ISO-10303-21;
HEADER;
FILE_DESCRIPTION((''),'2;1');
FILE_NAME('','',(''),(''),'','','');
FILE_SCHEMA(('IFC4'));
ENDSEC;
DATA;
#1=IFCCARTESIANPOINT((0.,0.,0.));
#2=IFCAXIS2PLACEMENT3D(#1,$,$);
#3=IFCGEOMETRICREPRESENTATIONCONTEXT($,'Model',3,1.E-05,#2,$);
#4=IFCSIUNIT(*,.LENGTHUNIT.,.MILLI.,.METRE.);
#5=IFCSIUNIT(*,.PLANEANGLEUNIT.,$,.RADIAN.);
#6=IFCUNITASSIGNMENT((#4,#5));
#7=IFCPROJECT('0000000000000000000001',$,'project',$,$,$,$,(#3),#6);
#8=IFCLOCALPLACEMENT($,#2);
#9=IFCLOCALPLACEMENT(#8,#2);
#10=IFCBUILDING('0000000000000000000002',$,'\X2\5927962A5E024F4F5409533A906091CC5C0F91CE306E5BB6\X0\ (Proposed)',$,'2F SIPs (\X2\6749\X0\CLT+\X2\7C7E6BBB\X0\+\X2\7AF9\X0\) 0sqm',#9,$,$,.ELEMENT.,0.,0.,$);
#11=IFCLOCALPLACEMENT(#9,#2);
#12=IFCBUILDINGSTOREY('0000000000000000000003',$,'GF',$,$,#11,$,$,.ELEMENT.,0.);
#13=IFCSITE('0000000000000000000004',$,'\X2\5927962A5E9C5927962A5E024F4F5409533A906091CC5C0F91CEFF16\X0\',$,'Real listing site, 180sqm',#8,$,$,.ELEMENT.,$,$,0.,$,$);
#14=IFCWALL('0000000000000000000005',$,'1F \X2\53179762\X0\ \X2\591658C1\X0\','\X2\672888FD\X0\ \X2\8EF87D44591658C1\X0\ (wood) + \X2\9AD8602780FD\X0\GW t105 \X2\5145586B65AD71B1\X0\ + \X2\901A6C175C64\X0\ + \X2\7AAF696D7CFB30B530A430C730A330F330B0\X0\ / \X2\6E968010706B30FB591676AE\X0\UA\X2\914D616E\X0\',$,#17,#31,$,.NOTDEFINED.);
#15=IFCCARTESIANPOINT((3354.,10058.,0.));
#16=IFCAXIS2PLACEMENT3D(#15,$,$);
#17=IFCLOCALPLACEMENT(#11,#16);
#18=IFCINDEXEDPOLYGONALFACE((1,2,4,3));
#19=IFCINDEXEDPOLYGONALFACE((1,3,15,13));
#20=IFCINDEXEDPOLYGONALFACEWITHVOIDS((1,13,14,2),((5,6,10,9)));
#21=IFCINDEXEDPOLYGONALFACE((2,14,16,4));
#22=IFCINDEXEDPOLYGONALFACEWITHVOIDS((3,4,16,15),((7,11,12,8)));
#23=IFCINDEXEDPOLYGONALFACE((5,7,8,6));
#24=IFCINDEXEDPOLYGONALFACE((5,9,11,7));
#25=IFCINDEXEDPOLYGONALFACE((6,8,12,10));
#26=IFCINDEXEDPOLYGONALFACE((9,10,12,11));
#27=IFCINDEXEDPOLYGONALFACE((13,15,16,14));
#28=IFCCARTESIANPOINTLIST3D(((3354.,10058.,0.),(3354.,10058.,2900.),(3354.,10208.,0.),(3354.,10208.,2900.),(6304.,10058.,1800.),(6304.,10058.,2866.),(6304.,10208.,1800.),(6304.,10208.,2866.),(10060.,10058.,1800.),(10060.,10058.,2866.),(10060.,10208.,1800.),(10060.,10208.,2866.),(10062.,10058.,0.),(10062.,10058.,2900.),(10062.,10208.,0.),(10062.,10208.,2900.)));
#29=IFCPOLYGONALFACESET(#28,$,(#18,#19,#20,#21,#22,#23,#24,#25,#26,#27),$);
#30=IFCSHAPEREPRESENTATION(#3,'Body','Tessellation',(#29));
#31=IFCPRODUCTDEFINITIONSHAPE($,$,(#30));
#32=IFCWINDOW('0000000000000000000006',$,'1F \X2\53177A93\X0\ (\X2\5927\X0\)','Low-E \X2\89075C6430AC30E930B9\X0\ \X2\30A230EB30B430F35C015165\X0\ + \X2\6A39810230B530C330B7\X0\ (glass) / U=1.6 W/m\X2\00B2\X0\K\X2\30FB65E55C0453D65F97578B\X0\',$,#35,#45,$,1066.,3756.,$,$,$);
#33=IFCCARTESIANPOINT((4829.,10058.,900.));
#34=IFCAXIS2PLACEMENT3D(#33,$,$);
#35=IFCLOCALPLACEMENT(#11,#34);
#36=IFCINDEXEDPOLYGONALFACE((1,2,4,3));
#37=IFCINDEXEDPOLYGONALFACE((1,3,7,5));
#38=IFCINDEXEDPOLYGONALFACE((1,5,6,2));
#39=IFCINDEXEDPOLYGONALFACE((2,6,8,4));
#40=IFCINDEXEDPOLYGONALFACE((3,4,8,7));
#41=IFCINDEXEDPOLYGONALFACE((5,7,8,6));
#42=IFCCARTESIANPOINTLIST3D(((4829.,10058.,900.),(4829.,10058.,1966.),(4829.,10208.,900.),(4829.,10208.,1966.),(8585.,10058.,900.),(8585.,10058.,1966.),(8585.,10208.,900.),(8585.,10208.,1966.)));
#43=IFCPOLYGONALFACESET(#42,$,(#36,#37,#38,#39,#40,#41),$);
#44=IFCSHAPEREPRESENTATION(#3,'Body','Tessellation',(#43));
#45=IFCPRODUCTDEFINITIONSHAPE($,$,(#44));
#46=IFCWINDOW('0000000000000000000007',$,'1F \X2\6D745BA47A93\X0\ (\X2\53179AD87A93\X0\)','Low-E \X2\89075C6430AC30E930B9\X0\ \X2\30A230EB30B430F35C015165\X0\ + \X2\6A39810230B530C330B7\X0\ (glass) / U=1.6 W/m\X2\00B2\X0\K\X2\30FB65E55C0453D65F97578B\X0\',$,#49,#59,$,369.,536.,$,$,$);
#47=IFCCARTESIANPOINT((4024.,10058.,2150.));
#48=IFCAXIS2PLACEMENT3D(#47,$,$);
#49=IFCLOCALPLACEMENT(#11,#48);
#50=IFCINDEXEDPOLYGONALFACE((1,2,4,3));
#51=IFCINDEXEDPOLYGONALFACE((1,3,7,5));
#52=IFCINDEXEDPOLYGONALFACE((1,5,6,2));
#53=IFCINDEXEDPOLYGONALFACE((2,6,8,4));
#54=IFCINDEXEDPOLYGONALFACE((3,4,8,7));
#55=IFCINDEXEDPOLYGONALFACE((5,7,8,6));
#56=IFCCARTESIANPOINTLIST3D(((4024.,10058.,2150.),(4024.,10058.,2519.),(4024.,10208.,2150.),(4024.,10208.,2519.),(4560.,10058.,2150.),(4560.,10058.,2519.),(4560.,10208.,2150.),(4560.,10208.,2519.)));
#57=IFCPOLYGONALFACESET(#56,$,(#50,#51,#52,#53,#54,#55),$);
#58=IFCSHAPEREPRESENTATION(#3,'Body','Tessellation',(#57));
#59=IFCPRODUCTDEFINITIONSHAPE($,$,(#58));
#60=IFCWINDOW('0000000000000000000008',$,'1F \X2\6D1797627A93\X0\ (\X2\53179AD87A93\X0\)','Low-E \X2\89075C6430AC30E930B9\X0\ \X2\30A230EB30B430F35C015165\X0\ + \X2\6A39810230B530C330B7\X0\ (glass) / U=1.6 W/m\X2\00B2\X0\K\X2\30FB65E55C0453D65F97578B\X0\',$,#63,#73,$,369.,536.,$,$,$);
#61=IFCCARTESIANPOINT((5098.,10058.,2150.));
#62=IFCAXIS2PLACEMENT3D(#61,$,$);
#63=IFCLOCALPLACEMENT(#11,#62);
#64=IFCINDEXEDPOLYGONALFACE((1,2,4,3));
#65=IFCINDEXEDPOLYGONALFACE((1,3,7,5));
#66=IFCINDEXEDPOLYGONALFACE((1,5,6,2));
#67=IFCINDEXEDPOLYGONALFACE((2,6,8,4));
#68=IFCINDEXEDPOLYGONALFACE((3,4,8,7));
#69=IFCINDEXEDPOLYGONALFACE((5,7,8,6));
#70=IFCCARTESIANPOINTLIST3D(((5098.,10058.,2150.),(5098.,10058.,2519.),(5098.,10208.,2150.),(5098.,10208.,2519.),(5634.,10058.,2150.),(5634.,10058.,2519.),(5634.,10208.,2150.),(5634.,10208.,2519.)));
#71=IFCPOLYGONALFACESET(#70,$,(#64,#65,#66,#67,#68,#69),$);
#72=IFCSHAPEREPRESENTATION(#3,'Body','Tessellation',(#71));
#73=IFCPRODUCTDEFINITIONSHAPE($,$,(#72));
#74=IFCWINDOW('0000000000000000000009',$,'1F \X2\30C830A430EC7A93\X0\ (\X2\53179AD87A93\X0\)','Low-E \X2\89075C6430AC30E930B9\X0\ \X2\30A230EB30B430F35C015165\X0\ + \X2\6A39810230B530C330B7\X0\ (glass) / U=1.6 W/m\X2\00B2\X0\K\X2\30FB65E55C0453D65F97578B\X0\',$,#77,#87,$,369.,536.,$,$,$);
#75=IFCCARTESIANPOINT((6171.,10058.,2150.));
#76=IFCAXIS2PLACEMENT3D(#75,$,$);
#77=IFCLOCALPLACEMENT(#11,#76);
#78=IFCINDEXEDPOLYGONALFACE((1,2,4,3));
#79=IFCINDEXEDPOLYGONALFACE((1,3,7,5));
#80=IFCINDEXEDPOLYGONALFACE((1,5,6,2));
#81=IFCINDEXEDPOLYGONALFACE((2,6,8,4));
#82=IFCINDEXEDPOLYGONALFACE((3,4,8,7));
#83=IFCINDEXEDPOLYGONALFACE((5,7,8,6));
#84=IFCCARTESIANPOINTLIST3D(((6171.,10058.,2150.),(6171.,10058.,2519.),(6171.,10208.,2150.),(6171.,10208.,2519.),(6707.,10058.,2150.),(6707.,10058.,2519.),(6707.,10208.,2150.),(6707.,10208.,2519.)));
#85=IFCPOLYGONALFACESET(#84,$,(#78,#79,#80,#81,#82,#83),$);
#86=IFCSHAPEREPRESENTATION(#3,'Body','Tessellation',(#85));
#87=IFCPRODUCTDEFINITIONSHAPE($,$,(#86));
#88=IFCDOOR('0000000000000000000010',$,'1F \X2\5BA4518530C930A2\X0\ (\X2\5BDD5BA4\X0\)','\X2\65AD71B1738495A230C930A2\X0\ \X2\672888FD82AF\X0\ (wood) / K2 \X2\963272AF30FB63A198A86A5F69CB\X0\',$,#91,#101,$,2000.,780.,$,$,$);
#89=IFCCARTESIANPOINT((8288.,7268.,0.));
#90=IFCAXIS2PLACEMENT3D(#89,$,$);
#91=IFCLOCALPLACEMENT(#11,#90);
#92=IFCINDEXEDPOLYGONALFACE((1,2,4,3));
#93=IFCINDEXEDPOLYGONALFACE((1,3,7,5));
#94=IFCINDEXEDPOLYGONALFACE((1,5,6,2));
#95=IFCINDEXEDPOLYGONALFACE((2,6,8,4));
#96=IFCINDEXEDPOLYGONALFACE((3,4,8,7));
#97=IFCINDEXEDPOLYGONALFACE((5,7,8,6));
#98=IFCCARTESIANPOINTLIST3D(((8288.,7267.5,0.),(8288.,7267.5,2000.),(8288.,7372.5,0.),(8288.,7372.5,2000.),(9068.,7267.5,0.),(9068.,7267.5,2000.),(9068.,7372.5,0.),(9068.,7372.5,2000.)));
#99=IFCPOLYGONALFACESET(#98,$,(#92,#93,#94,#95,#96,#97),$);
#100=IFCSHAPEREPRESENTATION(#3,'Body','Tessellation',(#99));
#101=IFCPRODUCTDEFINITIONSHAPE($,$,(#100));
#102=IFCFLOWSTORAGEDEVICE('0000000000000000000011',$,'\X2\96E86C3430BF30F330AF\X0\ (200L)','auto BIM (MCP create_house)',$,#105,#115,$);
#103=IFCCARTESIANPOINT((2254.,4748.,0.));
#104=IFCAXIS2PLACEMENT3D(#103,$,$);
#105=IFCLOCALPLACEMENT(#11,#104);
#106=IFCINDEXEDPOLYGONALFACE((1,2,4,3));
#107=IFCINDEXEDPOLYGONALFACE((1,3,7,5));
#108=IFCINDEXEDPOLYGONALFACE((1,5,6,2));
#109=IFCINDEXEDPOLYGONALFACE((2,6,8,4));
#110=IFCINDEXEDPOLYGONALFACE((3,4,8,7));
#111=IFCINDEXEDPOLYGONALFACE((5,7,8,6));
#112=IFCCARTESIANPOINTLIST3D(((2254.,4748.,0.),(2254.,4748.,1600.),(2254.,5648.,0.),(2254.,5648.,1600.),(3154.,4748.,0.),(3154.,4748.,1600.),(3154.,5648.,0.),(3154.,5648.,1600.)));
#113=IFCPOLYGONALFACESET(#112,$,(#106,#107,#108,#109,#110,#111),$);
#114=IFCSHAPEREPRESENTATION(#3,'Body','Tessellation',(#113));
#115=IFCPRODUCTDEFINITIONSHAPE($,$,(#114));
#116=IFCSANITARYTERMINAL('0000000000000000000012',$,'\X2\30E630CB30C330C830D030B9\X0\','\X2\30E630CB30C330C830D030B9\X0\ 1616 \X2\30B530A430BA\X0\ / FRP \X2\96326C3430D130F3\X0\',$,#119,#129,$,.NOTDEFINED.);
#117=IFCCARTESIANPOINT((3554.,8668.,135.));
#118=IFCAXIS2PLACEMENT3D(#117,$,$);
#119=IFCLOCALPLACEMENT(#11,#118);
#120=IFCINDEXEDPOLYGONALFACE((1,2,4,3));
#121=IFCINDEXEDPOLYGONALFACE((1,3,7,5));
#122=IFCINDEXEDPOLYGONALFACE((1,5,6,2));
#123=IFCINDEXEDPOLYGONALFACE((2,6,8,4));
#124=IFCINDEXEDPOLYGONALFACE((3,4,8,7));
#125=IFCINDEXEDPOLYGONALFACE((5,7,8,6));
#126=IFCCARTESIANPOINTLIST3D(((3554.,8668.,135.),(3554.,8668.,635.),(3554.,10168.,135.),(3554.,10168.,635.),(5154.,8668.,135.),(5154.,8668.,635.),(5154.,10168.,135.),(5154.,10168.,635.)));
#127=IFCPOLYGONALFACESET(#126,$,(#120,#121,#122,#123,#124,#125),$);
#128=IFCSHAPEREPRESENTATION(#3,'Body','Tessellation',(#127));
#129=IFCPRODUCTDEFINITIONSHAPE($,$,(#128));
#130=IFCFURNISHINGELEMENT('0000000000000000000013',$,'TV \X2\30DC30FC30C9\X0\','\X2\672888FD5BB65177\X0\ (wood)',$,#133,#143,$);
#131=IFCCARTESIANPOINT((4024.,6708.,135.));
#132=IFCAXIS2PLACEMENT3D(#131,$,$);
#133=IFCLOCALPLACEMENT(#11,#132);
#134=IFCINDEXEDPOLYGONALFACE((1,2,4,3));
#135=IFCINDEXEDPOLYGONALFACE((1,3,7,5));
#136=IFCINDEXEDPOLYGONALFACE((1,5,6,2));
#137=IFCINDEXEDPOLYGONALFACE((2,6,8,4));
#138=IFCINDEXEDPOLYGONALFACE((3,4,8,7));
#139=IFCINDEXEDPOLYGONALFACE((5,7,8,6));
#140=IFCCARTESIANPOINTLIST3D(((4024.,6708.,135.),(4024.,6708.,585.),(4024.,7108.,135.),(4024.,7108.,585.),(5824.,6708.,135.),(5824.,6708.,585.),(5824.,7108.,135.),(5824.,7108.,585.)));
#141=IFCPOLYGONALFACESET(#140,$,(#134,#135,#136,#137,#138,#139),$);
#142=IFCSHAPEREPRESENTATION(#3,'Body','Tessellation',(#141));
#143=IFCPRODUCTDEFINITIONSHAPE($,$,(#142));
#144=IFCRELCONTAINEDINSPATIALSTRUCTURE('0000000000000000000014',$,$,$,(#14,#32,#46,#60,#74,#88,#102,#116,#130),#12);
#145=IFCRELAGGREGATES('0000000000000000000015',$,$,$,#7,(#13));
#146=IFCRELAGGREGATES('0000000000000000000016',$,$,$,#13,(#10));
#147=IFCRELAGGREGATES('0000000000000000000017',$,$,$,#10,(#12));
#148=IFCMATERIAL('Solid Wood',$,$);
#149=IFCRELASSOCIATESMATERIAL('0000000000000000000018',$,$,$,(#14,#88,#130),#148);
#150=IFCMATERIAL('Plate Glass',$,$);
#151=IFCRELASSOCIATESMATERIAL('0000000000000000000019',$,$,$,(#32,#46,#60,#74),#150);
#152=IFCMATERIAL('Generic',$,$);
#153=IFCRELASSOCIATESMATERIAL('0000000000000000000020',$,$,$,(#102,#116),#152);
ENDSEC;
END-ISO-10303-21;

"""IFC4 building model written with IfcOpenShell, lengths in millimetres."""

from ifc_helpers import new_model, si_unit, frame, frame_2d, origin, place, context, project, spatial, rectangle, extrude, material, element, fill, save


model = new_model("IFC4")

# Units and contexts
model_context = context("Model", 3, precision=1e-05, world=origin())
ifc_project = project(units=[si_unit("LENGTHUNIT", "METRE", prefix="MILLI"), si_unit("PLANEANGLEUNIT", "RADIAN")], contexts=[model_context])

# Site, building, storey
site_placement = place(None, origin())
site = spatial("IfcSite", under=ifc_project, at=site_placement, Name="大阪府大阪市住吉区遠里小野６", ObjectType="Real listing site, 180sqm", CompositionType="ELEMENT", RefElevation=0.0)
building_placement = place(site_placement, origin())
building = spatial("IfcBuilding", under=site, at=building_placement, Name="大阪市住吉区遠里小野の家 (Proposed)", ObjectType="2F SIPs (杉CLT+籾殻+竹) 0sqm", CompositionType="ELEMENT", ElevationOfRefHeight=0.0, ElevationOfTerrain=0.0)
storey_placement = place(building_placement, origin())
storey = spatial("IfcBuildingStorey", under=building, at=storey_placement, Name="GF", CompositionType="ELEMENT", Elevation=0.0)

# Wall, openings, windows
ifc_material_1 = material(Name="Solid Wood")
wall_1_placement = place(storey_placement, frame((3354.0, 10058.0, 0.0)))
wall_1 = element("IfcWall", 1, at=wall_1_placement, inside=storey, material=ifc_material_1, Name="1F 北面 外壁", Description="木製 軸組外壁 (wood) + 高性能GW t105 充填断熱 + 通気層 + 窯業系サイディング / 準耐火・外皮UA配慮", PredefinedType="NOTDEFINED", context=model_context, shape_type="SweptSolid", body=[
    extrude(rectangle(XDim=6708.0, YDim=150.0, at=frame_2d((3354.0, 75.0))), frame((3354.0, 10058.0, 0.0)), (0.0, 0.0, 1.0), 2900.0),
])
opening_1_placement = place(storey_placement, frame((4829.0, 10058.0, 900.0)))
opening_1 = element("IfcOpeningElement", 2, at=opening_1_placement, cuts=wall_1, PredefinedType="NOTDEFINED", context=model_context, shape_type="SweptSolid", body=[
    extrude(rectangle(XDim=3756.0, YDim=150.0, at=frame_2d((1878.0, 75.0))), frame((4829.0, 10058.0, 900.0)), (0.0, 0.0, 1.0), 1066.0),
])
opening_2_placement = place(storey_placement, frame((4024.0, 10058.0, 2150.0)))
opening_2 = element("IfcOpeningElement", 3, at=opening_2_placement, cuts=wall_1, PredefinedType="NOTDEFINED", context=model_context, shape_type="SweptSolid", body=[
    extrude(rectangle(XDim=536.0, YDim=150.0, at=frame_2d((268.0, 75.0))), frame((4024.0, 10058.0, 2150.0)), (0.0, 0.0, 1.0), 369.0),
])
opening_3_placement = place(storey_placement, frame((5098.0, 10058.0, 2150.0)))
opening_3 = element("IfcOpeningElement", 4, at=opening_3_placement, cuts=wall_1, PredefinedType="NOTDEFINED", context=model_context, shape_type="SweptSolid", body=[
    extrude(rectangle(XDim=536.0, YDim=150.0, at=frame_2d((268.0, 75.0))), frame((5098.0, 10058.0, 2150.0)), (0.0, 0.0, 1.0), 369.0),
])
opening_4_placement = place(storey_placement, frame((6171.0, 10058.0, 2150.0)))
opening_4 = element("IfcOpeningElement", 5, at=opening_4_placement, cuts=wall_1, PredefinedType="NOTDEFINED", context=model_context, shape_type="SweptSolid", body=[
    extrude(rectangle(XDim=536.0, YDim=150.0, at=frame_2d((268.0, 75.0))), frame((6171.0, 10058.0, 2150.0)), (0.0, 0.0, 1.0), 369.0),
])
ifc_material_2 = material(Name="Plate Glass")
window_1_placement = place(storey_placement, frame((4829.0, 10058.0, 900.0)))
window_1 = element("IfcWindow", 6, at=window_1_placement, inside=storey, material=ifc_material_2, Name="1F 北窓 (大)", Description="Low-E 複層ガラス アルゴン封入 + 樹脂サッシ (glass) / U=1.6 W/m²K・日射取得型", OverallHeight=1066.0, OverallWidth=3756.0, context=model_context, shape_type="SweptSolid", body=[
    extrude(rectangle(XDim=3756.0, YDim=150.0, at=frame_2d((1878.0, 75.0))), frame((4829.0, 10058.0, 900.0)), (0.0, 0.0, 1.0), 1066.0),
])
fill(opening_1, window_1)
window_2_placement = place(storey_placement, frame((4024.0, 10058.0, 2150.0)))
window_2 = element("IfcWindow", 7, at=window_2_placement, inside=storey, material=ifc_material_2, Name="1F 浴室窓 (北高窓)", Description="Low-E 複層ガラス アルゴン封入 + 樹脂サッシ (glass) / U=1.6 W/m²K・日射取得型", OverallHeight=369.0, OverallWidth=536.0, context=model_context, shape_type="SweptSolid", body=[
    extrude(rectangle(XDim=536.0, YDim=150.0, at=frame_2d((268.0, 75.0))), frame((4024.0, 10058.0, 2150.0)), (0.0, 0.0, 1.0), 369.0),
])
fill(opening_2, window_2)
window_3_placement = place(storey_placement, frame((5098.0, 10058.0, 2150.0)))
window_3 = element("IfcWindow", 8, at=window_3_placement, inside=storey, material=ifc_material_2, Name="1F 洗面窓 (北高窓)", Description="Low-E 複層ガラス アルゴン封入 + 樹脂サッシ (glass) / U=1.6 W/m²K・日射取得型", OverallHeight=369.0, OverallWidth=536.0, context=model_context, shape_type="SweptSolid", body=[
    extrude(rectangle(XDim=536.0, YDim=150.0, at=frame_2d((268.0, 75.0))), frame((5098.0, 10058.0, 2150.0)), (0.0, 0.0, 1.0), 369.0),
])
fill(opening_3, window_3)
window_4_placement = place(storey_placement, frame((6171.0, 10058.0, 2150.0)))
window_4 = element("IfcWindow", 9, at=window_4_placement, inside=storey, material=ifc_material_2, Name="1F トイレ窓 (北高窓)", Description="Low-E 複層ガラス アルゴン封入 + 樹脂サッシ (glass) / U=1.6 W/m²K・日射取得型", OverallHeight=369.0, OverallWidth=536.0, context=model_context, shape_type="SweptSolid", body=[
    extrude(rectangle(XDim=536.0, YDim=150.0, at=frame_2d((268.0, 75.0))), frame((6171.0, 10058.0, 2150.0)), (0.0, 0.0, 1.0), 369.0),
])
fill(opening_4, window_4)

# Door
door_1_placement = place(storey_placement, frame((8288.0, 7268.0, 0.0)))
element("IfcDoor", 10, at=door_1_placement, inside=storey, material=ifc_material_1, Name="1F 室内ドア (寝室)", Description="断熱玄関ドア 木製芯 (wood) / K2 防犯・採風機構", OverallHeight=2000.0, OverallWidth=780.0, context=model_context, shape_type="SweptSolid", body=[
    extrude(rectangle(XDim=780.0, YDim=105.0, at=frame_2d((390.0, 52.0))), frame((8288.0, 7268.0, 0.0)), (0.0, 0.0, 1.0), 2000.0),
])

# Flow storage device
ifc_material_3 = material(Name="Generic")
flow_storage_device_placement = place(storey_placement, frame((2254.0, 4748.0, 0.0)))
element("IfcFlowStorageDevice", 11, at=flow_storage_device_placement, inside=storey, material=ifc_material_3, Name="雨水タンク (200L)", Description="auto BIM (MCP create_house)", context=model_context, shape_type="SweptSolid", body=[
    extrude(rectangle(XDim=900.0, YDim=900.0, at=frame_2d((450.0, 450.0))), frame((2254.0, 4748.0, 0.0)), (0.0, 0.0, 1.0), 1600.0),
])

# Sanitary terminal
sanitary_terminal_placement = place(storey_placement, frame((3554.0, 8668.0, 135.0)))
element("IfcSanitaryTerminal", 12, at=sanitary_terminal_placement, inside=storey, material=ifc_material_3, Name="ユニットバス", Description="ユニットバス 1616 サイズ / FRP 防水パン", PredefinedType="NOTDEFINED", context=model_context, shape_type="SweptSolid", body=[
    extrude(rectangle(XDim=1600.0, YDim=1500.0, at=frame_2d((800.0, 750.0))), frame((3554.0, 8668.0, 135.0)), (0.0, 0.0, 1.0), 500.0),
])

# Furnishing element
furnishing_placement = place(storey_placement, frame((4024.0, 6708.0, 135.0)))
element("IfcFurnishingElement", 13, at=furnishing_placement, inside=storey, material=ifc_material_1, Name="TV ボード", Description="木製家具 (wood)", context=model_context, shape_type="SweptSolid", body=[
    extrude(rectangle(XDim=1800.0, YDim=400.0, at=frame_2d((900.0, 200.0))), frame((4024.0, 6708.0, 135.0)), (0.0, 0.0, 1.0), 450.0),
])

save(model, "model.ifc")
